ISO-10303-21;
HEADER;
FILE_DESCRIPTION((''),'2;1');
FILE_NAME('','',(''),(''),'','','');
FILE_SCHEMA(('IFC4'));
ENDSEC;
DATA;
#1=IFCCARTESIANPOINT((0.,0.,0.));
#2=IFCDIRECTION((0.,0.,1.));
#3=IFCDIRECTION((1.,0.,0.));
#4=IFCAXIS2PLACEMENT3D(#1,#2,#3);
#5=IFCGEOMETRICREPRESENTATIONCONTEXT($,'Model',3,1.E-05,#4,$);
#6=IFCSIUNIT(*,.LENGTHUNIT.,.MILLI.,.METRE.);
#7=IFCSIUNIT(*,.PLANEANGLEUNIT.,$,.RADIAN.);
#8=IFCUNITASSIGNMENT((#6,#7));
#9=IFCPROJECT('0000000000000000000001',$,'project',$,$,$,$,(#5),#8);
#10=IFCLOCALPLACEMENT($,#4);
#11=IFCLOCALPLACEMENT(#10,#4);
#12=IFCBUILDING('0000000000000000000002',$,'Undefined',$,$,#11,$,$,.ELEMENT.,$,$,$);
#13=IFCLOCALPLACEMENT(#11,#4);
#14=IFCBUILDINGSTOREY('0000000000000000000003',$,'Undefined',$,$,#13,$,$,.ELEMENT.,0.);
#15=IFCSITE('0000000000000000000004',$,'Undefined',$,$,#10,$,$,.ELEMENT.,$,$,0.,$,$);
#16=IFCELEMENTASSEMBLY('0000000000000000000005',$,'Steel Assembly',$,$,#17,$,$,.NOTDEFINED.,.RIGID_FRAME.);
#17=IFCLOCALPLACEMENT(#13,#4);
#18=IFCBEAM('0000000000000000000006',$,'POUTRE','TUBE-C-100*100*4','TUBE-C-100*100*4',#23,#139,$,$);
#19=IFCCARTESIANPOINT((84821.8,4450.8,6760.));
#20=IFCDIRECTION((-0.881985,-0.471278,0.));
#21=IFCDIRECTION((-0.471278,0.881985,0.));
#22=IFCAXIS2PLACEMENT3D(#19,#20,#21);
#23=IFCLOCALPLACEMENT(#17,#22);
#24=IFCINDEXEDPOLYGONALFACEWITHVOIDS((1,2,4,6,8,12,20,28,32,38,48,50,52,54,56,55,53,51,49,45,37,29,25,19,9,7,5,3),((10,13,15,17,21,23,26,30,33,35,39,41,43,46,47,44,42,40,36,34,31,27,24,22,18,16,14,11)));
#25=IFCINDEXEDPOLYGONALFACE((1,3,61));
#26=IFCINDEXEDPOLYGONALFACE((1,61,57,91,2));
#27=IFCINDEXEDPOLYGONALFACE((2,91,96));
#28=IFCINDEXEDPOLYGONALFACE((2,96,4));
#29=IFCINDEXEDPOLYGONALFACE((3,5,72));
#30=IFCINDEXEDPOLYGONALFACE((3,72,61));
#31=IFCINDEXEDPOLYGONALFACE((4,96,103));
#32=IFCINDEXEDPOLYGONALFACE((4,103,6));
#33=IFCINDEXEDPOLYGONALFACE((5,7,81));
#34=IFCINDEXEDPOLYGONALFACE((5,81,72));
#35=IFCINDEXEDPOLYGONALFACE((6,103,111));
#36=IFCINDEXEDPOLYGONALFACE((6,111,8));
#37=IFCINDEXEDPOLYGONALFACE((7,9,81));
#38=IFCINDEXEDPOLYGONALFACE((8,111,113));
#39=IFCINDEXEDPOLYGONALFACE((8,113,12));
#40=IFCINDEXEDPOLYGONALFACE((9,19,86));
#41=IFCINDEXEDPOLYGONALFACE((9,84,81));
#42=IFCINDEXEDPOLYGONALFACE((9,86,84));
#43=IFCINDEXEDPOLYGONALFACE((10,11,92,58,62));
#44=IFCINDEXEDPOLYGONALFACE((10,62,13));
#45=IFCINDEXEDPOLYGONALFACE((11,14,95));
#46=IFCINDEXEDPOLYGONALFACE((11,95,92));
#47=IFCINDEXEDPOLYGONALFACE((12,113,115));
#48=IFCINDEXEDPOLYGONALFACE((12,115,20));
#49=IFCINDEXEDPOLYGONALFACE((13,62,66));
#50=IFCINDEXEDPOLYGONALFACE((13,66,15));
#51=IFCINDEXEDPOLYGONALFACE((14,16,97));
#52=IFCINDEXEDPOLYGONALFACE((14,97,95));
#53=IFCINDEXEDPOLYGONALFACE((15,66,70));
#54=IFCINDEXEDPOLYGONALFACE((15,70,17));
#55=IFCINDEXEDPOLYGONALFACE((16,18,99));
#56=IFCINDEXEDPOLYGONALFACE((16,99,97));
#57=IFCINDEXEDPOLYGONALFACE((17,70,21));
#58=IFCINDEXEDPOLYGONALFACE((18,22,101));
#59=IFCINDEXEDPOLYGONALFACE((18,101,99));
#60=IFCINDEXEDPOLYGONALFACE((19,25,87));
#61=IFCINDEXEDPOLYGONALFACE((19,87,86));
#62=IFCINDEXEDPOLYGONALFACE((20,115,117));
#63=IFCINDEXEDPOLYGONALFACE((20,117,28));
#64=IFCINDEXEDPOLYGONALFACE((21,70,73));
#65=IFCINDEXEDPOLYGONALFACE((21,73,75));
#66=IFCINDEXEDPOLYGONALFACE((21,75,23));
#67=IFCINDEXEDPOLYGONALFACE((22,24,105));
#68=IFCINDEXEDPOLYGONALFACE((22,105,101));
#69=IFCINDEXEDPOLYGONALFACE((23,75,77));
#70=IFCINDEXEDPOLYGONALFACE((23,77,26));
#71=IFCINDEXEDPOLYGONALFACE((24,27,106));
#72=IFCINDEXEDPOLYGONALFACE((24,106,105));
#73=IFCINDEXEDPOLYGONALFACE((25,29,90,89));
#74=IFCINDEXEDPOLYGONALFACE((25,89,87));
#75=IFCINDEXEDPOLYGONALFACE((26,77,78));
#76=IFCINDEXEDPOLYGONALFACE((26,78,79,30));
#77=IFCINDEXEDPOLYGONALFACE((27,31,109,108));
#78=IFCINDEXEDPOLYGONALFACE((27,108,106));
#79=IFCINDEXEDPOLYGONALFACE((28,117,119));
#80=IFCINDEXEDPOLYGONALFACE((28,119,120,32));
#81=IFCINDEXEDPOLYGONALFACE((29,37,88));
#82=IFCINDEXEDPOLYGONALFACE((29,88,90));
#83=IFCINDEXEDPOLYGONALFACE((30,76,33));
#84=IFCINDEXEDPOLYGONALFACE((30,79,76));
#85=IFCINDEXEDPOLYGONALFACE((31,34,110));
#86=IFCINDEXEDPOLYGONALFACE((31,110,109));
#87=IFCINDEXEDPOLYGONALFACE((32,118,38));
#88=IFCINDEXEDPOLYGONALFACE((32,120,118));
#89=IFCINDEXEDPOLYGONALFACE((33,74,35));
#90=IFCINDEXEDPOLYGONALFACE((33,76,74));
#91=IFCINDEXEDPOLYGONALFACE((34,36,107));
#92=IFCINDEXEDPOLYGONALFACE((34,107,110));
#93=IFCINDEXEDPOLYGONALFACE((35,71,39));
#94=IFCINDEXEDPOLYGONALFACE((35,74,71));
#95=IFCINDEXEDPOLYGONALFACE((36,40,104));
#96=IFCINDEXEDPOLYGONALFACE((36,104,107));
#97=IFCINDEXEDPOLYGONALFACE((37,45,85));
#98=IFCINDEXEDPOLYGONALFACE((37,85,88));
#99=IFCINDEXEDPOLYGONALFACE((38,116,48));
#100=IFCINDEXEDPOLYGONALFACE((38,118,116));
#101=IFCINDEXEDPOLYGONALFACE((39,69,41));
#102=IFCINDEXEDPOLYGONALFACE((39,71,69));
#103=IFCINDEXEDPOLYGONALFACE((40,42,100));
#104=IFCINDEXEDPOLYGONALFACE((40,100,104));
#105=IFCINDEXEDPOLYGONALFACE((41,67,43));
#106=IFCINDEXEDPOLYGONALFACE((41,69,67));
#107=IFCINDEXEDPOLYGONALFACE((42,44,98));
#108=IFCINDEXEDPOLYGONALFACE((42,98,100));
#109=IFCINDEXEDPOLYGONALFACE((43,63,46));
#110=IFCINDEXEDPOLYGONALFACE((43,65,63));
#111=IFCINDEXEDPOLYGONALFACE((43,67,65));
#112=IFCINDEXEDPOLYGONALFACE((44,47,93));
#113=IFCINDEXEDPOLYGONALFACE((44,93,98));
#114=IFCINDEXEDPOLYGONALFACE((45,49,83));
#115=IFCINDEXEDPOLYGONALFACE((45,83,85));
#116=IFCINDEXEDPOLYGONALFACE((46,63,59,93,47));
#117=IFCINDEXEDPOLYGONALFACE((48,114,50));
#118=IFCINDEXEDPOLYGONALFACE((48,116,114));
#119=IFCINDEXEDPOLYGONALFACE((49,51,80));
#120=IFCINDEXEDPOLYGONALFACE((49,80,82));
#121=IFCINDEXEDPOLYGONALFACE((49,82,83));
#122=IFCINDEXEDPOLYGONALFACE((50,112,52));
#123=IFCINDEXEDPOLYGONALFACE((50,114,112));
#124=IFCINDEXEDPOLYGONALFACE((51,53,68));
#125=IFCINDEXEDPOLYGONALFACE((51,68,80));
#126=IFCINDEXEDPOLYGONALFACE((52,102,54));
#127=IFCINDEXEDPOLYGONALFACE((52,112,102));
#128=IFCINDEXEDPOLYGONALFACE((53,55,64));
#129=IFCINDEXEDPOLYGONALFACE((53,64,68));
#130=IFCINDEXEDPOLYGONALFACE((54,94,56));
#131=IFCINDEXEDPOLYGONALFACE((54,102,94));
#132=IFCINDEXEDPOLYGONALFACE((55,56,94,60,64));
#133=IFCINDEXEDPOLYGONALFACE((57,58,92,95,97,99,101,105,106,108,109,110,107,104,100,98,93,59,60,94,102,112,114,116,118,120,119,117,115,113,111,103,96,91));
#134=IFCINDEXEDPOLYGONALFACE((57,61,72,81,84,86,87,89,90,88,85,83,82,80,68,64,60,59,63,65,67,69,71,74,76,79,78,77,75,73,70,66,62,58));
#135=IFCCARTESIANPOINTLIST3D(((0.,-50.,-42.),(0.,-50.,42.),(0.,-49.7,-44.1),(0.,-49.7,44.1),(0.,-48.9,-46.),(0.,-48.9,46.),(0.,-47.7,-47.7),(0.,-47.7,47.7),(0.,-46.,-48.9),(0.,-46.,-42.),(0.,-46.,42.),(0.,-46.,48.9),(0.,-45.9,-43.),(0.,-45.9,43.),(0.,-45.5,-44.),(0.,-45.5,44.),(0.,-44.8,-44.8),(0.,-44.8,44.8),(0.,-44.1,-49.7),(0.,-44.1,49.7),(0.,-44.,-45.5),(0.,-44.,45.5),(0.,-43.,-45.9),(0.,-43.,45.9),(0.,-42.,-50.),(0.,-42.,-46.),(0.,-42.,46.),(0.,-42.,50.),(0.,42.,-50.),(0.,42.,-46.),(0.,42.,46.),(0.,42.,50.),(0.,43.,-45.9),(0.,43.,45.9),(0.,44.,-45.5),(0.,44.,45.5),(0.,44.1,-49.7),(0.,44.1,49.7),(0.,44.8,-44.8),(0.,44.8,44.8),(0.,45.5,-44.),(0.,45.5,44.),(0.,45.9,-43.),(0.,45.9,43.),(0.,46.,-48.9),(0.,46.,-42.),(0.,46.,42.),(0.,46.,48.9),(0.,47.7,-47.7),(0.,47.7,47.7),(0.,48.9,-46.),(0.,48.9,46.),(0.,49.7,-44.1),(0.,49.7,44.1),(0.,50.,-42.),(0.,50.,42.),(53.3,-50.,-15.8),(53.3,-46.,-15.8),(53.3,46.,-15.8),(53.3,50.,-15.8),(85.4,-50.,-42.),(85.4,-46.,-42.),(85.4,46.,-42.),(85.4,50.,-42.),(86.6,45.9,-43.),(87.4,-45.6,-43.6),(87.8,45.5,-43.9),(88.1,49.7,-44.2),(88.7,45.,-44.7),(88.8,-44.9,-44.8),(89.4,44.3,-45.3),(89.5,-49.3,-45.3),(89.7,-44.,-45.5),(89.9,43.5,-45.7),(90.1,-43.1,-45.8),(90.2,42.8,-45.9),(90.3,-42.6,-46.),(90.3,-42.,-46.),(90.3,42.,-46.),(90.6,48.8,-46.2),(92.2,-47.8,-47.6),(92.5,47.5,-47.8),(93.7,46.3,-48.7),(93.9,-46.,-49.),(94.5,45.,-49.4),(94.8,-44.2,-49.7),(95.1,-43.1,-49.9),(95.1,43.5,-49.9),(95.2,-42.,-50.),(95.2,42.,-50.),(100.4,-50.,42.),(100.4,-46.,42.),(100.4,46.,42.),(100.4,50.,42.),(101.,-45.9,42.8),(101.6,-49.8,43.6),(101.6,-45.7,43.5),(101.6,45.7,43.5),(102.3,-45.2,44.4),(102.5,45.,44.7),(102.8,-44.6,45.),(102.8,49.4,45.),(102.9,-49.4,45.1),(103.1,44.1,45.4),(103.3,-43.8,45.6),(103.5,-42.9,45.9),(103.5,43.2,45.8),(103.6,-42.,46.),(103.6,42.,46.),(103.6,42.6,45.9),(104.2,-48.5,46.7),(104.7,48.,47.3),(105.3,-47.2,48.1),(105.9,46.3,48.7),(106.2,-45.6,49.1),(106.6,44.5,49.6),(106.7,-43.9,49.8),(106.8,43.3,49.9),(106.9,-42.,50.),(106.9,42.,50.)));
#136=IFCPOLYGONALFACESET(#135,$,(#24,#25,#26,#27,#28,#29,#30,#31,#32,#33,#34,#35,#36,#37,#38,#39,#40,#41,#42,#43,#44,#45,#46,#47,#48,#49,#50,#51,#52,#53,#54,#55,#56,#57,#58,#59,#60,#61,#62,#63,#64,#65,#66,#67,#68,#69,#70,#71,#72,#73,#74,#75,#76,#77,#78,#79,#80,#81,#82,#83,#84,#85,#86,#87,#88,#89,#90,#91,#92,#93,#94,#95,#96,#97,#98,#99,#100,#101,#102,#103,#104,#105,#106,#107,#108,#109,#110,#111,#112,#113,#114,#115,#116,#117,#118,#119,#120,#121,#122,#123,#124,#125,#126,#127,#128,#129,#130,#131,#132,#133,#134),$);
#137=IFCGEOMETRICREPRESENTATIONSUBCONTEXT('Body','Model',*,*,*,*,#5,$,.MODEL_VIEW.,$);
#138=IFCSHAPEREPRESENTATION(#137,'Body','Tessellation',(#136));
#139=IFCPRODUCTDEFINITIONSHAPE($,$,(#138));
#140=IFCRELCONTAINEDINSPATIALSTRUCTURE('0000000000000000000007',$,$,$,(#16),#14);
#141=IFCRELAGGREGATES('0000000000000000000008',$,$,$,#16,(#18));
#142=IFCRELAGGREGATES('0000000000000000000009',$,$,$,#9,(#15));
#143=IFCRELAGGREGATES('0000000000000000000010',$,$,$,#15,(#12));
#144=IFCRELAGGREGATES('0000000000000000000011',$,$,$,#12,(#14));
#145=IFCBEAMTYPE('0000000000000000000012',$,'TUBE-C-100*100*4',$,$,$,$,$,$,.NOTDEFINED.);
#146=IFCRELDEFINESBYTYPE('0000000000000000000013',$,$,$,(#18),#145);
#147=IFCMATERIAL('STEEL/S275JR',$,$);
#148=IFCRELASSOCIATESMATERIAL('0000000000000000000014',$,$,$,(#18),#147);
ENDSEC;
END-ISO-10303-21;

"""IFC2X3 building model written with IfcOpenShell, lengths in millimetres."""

from ifc_helpers import new_model, si_unit, frame, origin_with_axes, origin_2d_with_axis, place, context, subcontext, project, spatial, polyline, hollow_rectangle, outline, extrude, boolean, material, type_object, element, aggregate, save


model = new_model("IFC2X3")

# Units and contexts
model_context = context("Model", 3, precision=1e-05, world=origin_with_axes())
body_context = subcontext(model_context, "Body", "Model", "MODEL_VIEW")
ifc_project = project(units=[si_unit("LENGTHUNIT", "METRE", prefix="MILLI"), si_unit("PLANEANGLEUNIT", "RADIAN")], contexts=[model_context])

# Site, building, storey
site_placement = place(None, origin_with_axes())
site = spatial("IfcSite", under=ifc_project, at=site_placement, Name="Undefined", CompositionType="ELEMENT", RefElevation=0.0)
building_placement = place(site_placement, origin_with_axes())
building = spatial("IfcBuilding", under=site, at=building_placement, Name="Undefined", CompositionType="ELEMENT")
storey_placement = place(building_placement, origin_with_axes())
storey = spatial("IfcBuildingStorey", under=building, at=storey_placement, Name="Undefined", CompositionType="ELEMENT", Elevation=0.0)

# Element assembly, beam
ifc_material_1 = material(Name="STEEL/S275JR")
beam_type_1 = type_object("IfcBeamType", Name="TUBE-C-100*100*4", PredefinedType="NOTDEFINED")
assembly_1_placement = place(storey_placement, origin_with_axes())
assembly_1 = element("IfcElementAssembly", 1, at=assembly_1_placement, inside=storey, Name="Steel Assembly", AssemblyPlace="NOTDEFINED", PredefinedType="RIGID_FRAME")
beam_1_placement = place(assembly_1_placement, frame((84821.8, 4450.8, 6760.0), z_axis=(-0.881985, -0.471278, 0.0), x_axis=(-0.471278, 0.881985, 0.0)))
beam_1 = element("IfcBeam", 2, at=beam_1_placement, type_object=beam_type_1, material=ifc_material_1, Name="POUTRE", Description="TUBE-C-100*100*4", ObjectType="TUBE-C-100*100*4", context=body_context, shape_type="CSG", body=[
    boolean("DIFFERENCE", extrude(hollow_rectangle(XDim=100.0, YDim=100.0, WallThickness=4.0, InnerFilletRadius=4.0, OuterFilletRadius=8.0, at=origin_2d_with_axis()), frame((158.0, 0.0, 0.0), z_axis=(-1.0, 0.0, 0.0), x_axis=(0.0, -1.0, 0.0)), (0.0, 0.0, 1.0), 158.0), extrude(outline(polyline([(0.0, 0.0), (84.9, 0.0), (84.9, 54.1), (45.2, 102.8), (-32.3, 39.6), (0.0, 0.0)])), frame((106.9, 52.5, 50.0), z_axis=(0.0, -1.0, 0.0), x_axis=(-0.63174, 0.0, -0.77518)), (0.0, 0.0, 1.0), 105.0)),
])
aggregate(assembly_1, [beam_1])

save(model, "model.ifc")
